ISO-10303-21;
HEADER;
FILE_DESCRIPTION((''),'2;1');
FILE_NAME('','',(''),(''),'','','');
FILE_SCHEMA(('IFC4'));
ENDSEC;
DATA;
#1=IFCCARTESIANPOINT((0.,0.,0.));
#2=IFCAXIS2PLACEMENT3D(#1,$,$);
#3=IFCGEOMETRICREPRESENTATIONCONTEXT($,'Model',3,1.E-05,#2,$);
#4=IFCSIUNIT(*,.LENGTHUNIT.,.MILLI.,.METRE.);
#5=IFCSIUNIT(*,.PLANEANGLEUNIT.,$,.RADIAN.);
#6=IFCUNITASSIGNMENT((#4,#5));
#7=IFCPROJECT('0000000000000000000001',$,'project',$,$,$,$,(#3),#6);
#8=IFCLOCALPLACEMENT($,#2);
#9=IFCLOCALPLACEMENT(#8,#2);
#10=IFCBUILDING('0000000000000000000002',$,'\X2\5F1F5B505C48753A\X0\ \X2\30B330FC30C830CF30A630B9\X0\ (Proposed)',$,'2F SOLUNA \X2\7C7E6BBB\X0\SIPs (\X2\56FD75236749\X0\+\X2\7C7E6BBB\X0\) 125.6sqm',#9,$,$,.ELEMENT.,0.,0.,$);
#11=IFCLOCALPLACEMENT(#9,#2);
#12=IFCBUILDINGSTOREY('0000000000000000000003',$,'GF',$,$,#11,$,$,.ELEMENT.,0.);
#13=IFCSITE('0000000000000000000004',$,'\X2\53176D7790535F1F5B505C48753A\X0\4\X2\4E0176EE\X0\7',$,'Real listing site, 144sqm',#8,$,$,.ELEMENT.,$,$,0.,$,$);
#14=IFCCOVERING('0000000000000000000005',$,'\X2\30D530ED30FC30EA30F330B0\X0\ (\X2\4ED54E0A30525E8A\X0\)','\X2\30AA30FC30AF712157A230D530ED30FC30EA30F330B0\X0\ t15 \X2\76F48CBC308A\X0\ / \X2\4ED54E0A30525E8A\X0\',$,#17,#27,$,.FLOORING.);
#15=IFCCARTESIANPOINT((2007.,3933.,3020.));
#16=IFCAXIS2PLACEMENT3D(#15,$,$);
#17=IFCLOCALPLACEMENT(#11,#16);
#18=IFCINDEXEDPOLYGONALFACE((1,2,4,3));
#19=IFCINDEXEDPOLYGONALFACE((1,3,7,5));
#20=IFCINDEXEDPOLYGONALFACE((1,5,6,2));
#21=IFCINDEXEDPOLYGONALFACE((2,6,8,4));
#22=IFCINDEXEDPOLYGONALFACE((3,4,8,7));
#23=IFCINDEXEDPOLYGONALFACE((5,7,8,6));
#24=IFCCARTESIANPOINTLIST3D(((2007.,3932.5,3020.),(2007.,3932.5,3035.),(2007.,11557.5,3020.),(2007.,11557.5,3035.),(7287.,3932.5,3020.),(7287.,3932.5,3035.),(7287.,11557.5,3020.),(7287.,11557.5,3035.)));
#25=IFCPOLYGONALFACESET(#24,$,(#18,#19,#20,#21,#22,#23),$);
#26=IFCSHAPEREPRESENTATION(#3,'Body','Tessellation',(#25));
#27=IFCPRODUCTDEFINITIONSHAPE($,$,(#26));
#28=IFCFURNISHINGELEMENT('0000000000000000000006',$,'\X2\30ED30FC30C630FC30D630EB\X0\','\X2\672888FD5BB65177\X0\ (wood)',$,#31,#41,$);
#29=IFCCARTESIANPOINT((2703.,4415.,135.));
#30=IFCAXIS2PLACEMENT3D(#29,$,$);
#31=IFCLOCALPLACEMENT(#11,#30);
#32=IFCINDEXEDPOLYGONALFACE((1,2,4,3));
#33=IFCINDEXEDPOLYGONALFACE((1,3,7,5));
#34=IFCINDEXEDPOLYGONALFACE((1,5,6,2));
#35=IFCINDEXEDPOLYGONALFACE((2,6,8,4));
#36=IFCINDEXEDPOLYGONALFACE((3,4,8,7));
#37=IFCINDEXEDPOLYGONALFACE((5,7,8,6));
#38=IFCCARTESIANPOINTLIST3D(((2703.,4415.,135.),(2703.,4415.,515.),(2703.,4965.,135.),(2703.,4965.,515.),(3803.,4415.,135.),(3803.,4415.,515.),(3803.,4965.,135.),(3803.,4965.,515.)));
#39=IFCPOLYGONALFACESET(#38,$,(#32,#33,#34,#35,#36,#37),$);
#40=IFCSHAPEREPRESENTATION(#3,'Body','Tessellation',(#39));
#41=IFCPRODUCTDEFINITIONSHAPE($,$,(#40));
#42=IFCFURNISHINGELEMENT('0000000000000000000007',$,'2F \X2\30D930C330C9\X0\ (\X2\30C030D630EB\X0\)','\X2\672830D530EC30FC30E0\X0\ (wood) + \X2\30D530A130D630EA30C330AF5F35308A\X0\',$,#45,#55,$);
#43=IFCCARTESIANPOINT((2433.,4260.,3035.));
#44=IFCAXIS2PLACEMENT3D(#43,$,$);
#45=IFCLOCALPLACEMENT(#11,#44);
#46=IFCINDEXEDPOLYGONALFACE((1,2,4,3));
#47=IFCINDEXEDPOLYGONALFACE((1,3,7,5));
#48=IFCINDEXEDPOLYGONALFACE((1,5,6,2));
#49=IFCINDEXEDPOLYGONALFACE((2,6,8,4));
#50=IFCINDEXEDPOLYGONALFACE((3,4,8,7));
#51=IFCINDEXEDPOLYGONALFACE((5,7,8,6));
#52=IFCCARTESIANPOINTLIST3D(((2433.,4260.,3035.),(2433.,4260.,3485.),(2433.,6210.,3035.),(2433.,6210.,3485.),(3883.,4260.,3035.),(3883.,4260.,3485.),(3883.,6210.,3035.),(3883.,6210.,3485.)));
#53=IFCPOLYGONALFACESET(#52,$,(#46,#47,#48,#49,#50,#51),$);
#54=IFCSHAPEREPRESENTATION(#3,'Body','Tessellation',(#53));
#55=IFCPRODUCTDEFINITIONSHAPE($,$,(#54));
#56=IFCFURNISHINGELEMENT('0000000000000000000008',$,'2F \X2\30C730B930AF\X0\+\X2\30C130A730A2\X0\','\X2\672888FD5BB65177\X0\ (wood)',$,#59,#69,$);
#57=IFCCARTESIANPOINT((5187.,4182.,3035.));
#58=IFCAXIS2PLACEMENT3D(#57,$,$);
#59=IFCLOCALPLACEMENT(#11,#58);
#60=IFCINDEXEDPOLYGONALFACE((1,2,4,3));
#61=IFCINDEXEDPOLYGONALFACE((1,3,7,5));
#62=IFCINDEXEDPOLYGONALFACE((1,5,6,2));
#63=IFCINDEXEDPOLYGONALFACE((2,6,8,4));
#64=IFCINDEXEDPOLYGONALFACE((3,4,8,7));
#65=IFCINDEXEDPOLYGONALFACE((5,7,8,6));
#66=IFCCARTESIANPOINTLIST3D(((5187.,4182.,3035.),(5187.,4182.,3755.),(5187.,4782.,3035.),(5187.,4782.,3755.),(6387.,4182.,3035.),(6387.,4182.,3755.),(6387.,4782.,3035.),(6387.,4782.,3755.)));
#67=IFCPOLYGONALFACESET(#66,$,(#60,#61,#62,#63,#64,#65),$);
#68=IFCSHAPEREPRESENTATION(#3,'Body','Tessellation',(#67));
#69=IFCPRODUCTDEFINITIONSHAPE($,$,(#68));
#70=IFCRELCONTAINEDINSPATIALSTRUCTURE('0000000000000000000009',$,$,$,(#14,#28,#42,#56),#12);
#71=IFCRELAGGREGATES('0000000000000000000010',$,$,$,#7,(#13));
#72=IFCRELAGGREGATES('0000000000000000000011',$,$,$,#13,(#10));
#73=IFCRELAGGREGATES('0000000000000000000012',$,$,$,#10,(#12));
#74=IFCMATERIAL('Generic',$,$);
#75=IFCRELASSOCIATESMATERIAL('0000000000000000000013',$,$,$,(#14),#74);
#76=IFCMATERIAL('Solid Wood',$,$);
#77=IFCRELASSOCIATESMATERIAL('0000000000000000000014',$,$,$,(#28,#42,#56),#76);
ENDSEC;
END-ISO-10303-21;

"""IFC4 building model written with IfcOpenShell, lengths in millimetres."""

from ifc_helpers import new_model, si_unit, frame, frame_2d, origin, place, context, project, spatial, rectangle, extrude, material, element, save


model = new_model("IFC4")

# Units and contexts
model_context = context("Model", 3, precision=1e-05, world=origin())
ifc_project = project(units=[si_unit("LENGTHUNIT", "METRE", prefix="MILLI"), si_unit("PLANEANGLEUNIT", "RADIAN")], contexts=[model_context])

# Site, building, storey
site_placement = place(None, origin())
site = spatial("IfcSite", under=ifc_project, at=site_placement, Name="北海道弟子屈町4丁目7", ObjectType="Real listing site, 144sqm", CompositionType="ELEMENT", RefElevation=0.0)
building_placement = place(site_placement, origin())
building = spatial("IfcBuilding", under=site, at=building_placement, Name="弟子屈町 コートハウス (Proposed)", ObjectType="2F SOLUNA 籾殻SIPs (国産杉+籾殻) 125.6sqm", CompositionType="ELEMENT", ElevationOfRefHeight=0.0, ElevationOfTerrain=0.0)
storey_placement = place(building_placement, origin())
storey = spatial("IfcBuildingStorey", under=building, at=storey_placement, Name="GF", CompositionType="ELEMENT", Elevation=0.0)

# Shared definitions
ifc_material_1 = material(Name="Solid Wood")

# Shared definitions
ifc_material_2 = material(Name="Generic")

# Covering
covering_placement = place(storey_placement, frame((2007.0, 3933.0, 3020.0)))
element("IfcCovering", 1, at=covering_placement, inside=storey, material=ifc_material_2, Name="フローリング (仕上げ床)", Description="オーク無垢フローリング t15 直貼り / 仕上げ床", PredefinedType="FLOORING", context=model_context, shape_type="SweptSolid", body=[
    extrude(rectangle(XDim=5280.0, YDim=7625.0, at=frame_2d((2640.0, 3812.0))), frame((2007.0, 3933.0, 3020.0)), (0.0, 0.0, 1.0), 15.0),
])

# Furnishing elements
furnishing_1_placement = place(storey_placement, frame((2703.0, 4415.0, 135.0)))
element("IfcFurnishingElement", 2, at=furnishing_1_placement, inside=storey, material=ifc_material_1, Name="ローテーブル", Description="木製家具 (wood)", context=model_context, shape_type="SweptSolid", body=[
    extrude(rectangle(XDim=1100.0, YDim=550.0, at=frame_2d((550.0, 275.0))), frame((2703.0, 4415.0, 135.0)), (0.0, 0.0, 1.0), 380.0),
])
furnishing_2_placement = place(storey_placement, frame((2433.0, 4260.0, 3035.0)))
element("IfcFurnishingElement", 3, at=furnishing_2_placement, inside=storey, material=ifc_material_1, Name="2F ベッド (ダブル)", Description="木フレーム (wood) + ファブリック張り", context=model_context, shape_type="SweptSolid", body=[
    extrude(rectangle(XDim=1450.0, YDim=1950.0, at=frame_2d((725.0, 975.0))), frame((2433.0, 4260.0, 3035.0)), (0.0, 0.0, 1.0), 450.0),
])
furnishing_3_placement = place(storey_placement, frame((5187.0, 4182.0, 3035.0)))
element("IfcFurnishingElement", 4, at=furnishing_3_placement, inside=storey, material=ifc_material_1, Name="2F デスク+チェア", Description="木製家具 (wood)", context=model_context, shape_type="SweptSolid", body=[
    extrude(rectangle(XDim=1200.0, YDim=600.0, at=frame_2d((600.0, 300.0))), frame((5187.0, 4182.0, 3035.0)), (0.0, 0.0, 1.0), 720.0),
])

save(model, "model.ifc")
